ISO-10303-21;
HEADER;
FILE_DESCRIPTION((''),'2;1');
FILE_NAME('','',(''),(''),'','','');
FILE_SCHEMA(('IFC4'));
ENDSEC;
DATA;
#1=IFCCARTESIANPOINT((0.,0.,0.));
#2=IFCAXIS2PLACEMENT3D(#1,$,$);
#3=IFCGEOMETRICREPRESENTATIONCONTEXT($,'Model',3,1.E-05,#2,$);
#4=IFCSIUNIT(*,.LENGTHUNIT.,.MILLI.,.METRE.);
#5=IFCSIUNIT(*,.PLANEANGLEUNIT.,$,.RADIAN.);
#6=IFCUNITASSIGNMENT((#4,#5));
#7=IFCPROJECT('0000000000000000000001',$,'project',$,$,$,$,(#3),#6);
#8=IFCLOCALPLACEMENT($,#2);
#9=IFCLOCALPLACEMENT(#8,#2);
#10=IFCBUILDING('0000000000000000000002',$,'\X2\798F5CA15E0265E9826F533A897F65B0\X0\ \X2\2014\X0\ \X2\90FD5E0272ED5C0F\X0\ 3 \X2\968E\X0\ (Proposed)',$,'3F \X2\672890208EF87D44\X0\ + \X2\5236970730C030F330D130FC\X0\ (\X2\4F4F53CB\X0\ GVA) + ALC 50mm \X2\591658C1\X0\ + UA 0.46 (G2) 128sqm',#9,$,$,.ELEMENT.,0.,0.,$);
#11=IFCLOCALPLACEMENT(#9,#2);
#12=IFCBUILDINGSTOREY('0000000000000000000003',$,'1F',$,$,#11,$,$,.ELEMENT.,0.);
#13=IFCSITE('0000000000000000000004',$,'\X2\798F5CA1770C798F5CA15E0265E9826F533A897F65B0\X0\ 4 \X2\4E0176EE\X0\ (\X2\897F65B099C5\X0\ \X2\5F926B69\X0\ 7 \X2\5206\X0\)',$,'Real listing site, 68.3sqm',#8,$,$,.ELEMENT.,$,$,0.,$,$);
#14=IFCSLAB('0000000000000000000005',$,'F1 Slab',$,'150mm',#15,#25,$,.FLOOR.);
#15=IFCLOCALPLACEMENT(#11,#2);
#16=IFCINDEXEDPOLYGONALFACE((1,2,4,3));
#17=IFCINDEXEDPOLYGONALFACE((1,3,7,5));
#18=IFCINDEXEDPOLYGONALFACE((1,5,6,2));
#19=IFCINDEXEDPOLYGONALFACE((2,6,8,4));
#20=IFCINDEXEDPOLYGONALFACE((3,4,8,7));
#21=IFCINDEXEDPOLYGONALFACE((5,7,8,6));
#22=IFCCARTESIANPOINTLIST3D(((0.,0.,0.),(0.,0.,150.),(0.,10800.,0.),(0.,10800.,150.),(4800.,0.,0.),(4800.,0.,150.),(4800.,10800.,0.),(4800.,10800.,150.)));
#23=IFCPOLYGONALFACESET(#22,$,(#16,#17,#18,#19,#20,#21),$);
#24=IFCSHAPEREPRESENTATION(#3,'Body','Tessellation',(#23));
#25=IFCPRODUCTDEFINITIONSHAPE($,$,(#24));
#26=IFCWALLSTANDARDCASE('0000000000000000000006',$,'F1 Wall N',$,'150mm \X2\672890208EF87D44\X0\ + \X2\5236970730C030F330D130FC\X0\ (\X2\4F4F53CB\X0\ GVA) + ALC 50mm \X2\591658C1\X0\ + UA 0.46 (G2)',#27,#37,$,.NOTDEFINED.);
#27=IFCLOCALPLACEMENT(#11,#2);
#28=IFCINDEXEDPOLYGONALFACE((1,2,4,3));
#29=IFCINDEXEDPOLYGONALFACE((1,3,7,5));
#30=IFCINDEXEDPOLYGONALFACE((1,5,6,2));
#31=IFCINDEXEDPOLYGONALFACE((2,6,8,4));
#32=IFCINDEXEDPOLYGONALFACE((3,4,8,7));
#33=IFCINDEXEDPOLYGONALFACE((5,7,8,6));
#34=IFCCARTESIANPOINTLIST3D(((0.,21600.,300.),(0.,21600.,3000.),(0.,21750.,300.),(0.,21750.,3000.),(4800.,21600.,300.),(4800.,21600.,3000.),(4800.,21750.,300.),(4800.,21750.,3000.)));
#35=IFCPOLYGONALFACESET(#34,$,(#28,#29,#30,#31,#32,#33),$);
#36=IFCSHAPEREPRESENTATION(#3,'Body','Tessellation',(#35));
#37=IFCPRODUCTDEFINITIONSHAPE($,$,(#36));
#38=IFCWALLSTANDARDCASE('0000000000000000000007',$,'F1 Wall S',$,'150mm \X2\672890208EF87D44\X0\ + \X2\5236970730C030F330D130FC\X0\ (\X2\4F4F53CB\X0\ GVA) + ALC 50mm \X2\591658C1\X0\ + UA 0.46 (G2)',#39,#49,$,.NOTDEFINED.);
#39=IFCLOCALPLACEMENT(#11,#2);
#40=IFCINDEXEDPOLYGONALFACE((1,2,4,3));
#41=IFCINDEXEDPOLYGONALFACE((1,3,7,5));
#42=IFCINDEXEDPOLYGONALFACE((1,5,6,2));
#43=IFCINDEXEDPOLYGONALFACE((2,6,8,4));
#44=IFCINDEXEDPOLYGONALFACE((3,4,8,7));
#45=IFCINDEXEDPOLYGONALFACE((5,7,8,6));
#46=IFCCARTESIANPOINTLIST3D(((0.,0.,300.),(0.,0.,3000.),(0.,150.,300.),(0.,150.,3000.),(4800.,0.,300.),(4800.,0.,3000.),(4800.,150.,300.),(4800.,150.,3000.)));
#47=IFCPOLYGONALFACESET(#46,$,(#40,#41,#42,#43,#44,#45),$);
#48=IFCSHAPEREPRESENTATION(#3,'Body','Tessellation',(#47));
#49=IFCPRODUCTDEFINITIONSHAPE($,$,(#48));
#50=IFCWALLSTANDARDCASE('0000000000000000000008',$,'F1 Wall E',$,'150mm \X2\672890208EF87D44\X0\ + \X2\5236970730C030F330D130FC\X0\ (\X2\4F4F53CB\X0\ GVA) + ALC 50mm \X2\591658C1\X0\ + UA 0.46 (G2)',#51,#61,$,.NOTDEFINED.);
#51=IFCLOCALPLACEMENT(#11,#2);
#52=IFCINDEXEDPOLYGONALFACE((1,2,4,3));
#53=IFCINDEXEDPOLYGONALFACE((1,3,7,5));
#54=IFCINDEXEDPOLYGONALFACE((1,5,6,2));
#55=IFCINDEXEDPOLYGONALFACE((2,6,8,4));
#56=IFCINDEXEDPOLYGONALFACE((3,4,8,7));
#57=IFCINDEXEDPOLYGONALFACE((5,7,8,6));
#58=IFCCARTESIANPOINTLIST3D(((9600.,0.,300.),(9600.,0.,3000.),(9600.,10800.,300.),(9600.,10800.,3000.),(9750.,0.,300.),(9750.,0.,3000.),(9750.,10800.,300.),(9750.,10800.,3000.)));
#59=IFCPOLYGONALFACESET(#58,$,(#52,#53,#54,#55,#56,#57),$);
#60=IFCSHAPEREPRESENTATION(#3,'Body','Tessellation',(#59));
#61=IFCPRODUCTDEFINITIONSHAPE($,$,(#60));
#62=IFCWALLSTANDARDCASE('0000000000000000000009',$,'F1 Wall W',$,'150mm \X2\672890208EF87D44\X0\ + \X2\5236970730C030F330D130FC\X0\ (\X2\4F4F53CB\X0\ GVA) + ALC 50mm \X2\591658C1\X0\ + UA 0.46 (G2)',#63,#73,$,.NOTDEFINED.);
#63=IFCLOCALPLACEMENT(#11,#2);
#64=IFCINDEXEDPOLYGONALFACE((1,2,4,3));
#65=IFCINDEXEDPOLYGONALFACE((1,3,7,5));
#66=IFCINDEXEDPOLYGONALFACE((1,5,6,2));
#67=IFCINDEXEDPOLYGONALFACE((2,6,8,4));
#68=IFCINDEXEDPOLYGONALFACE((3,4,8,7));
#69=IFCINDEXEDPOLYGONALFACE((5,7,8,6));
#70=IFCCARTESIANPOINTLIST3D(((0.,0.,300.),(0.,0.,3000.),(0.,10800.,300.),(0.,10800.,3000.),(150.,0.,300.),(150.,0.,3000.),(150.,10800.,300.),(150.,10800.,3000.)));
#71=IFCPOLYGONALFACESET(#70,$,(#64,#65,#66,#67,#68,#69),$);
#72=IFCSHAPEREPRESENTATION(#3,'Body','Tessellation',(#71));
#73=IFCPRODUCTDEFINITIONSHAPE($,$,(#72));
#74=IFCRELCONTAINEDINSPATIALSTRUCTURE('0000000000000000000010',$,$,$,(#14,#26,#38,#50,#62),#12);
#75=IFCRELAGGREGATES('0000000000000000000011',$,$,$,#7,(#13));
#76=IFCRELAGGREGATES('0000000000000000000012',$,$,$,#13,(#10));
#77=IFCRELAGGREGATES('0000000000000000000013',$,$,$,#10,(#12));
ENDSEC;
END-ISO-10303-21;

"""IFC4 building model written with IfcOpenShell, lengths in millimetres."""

from ifc_helpers import new_model, si_unit, frame, frame_2d, origin, place, context, project, spatial, rectangle, extrude, element, save


model = new_model("IFC4")

# Units and contexts
model_context = context("Model", 3, precision=1e-05, world=origin())
ifc_project = project(units=[si_unit("LENGTHUNIT", "METRE", prefix="MILLI"), si_unit("PLANEANGLEUNIT", "RADIAN")], contexts=[model_context])

# Site, building, storey
site_placement = place(None, origin())
site = spatial("IfcSite", under=ifc_project, at=site_placement, Name="福岡県福岡市早良区西新 4 丁目 (西新駅 徒歩 7 分)", ObjectType="Real listing site, 68.3sqm", CompositionType="ELEMENT", RefElevation=0.0)
building_placement = place(site_placement, origin())
building = spatial("IfcBuilding", under=site, at=building_placement, Name="福岡市早良区西新 — 都市狭小 3 階 (Proposed)", ObjectType="3F 木造軸組 + 制震ダンパー (住友 GVA) + ALC 50mm 外壁 + UA 0.46 (G2) 128sqm", CompositionType="ELEMENT", ElevationOfRefHeight=0.0, ElevationOfTerrain=0.0)
storey_placement = place(building_placement, origin())
storey = spatial("IfcBuildingStorey", under=building, at=storey_placement, Name="1F", CompositionType="ELEMENT", Elevation=0.0)

# Slab
slab_placement = place(storey_placement, origin())
element("IfcSlab", 1, at=slab_placement, inside=storey, Name="F1 Slab", ObjectType="150mm", PredefinedType="FLOOR", context=model_context, shape_type="SweptSolid", body=[
    extrude(rectangle(XDim=4800.0, YDim=10800.0, at=frame_2d((2400.0, 5400.0))), origin(), (0.0, 0.0, 1.0), 150.0),
])

# Walls
wall_1_placement = place(storey_placement, frame((0.0, 10800.0, 150.0)))
element("IfcWallStandardCase", 2, at=wall_1_placement, inside=storey, Name="F1 Wall N", ObjectType="150mm 木造軸組 + 制震ダンパー (住友 GVA) + ALC 50mm 外壁 + UA 0.46 (G2)", PredefinedType="NOTDEFINED", context=model_context, shape_type="SweptSolid", body=[
    extrude(rectangle(XDim=4800.0, YDim=150.0, at=frame_2d((2400.0, 75.0))), frame((0.0, 10800.0, 150.0)), (0.0, 0.0, 1.0), 2700.0),
])
wall_2_placement = place(storey_placement, frame((0.0, 0.0, 150.0)))
element("IfcWallStandardCase", 3, at=wall_2_placement, inside=storey, Name="F1 Wall S", ObjectType="150mm 木造軸組 + 制震ダンパー (住友 GVA) + ALC 50mm 外壁 + UA 0.46 (G2)", PredefinedType="NOTDEFINED", context=model_context, shape_type="SweptSolid", body=[
    extrude(rectangle(XDim=4800.0, YDim=150.0, at=frame_2d((2400.0, 75.0))), frame((0.0, 0.0, 150.0)), (0.0, 0.0, 1.0), 2700.0),
])
wall_3_placement = place(storey_placement, frame((4800.0, 0.0, 150.0)))
element("IfcWallStandardCase", 4, at=wall_3_placement, inside=storey, Name="F1 Wall E", ObjectType="150mm 木造軸組 + 制震ダンパー (住友 GVA) + ALC 50mm 外壁 + UA 0.46 (G2)", PredefinedType="NOTDEFINED", context=model_context, shape_type="SweptSolid", body=[
    extrude(rectangle(XDim=150.0, YDim=10800.0, at=frame_2d((75.0, 5400.0))), frame((4800.0, 0.0, 150.0)), (0.0, 0.0, 1.0), 2700.0),
])
wall_4_placement = place(storey_placement, frame((0.0, 0.0, 150.0)))
element("IfcWallStandardCase", 5, at=wall_4_placement, inside=storey, Name="F1 Wall W", ObjectType="150mm 木造軸組 + 制震ダンパー (住友 GVA) + ALC 50mm 外壁 + UA 0.46 (G2)", PredefinedType="NOTDEFINED", context=model_context, shape_type="SweptSolid", body=[
    extrude(rectangle(XDim=150.0, YDim=10800.0, at=frame_2d((75.0, 5400.0))), frame((0.0, 0.0, 150.0)), (0.0, 0.0, 1.0), 2700.0),
])

save(model, "model.ifc")
